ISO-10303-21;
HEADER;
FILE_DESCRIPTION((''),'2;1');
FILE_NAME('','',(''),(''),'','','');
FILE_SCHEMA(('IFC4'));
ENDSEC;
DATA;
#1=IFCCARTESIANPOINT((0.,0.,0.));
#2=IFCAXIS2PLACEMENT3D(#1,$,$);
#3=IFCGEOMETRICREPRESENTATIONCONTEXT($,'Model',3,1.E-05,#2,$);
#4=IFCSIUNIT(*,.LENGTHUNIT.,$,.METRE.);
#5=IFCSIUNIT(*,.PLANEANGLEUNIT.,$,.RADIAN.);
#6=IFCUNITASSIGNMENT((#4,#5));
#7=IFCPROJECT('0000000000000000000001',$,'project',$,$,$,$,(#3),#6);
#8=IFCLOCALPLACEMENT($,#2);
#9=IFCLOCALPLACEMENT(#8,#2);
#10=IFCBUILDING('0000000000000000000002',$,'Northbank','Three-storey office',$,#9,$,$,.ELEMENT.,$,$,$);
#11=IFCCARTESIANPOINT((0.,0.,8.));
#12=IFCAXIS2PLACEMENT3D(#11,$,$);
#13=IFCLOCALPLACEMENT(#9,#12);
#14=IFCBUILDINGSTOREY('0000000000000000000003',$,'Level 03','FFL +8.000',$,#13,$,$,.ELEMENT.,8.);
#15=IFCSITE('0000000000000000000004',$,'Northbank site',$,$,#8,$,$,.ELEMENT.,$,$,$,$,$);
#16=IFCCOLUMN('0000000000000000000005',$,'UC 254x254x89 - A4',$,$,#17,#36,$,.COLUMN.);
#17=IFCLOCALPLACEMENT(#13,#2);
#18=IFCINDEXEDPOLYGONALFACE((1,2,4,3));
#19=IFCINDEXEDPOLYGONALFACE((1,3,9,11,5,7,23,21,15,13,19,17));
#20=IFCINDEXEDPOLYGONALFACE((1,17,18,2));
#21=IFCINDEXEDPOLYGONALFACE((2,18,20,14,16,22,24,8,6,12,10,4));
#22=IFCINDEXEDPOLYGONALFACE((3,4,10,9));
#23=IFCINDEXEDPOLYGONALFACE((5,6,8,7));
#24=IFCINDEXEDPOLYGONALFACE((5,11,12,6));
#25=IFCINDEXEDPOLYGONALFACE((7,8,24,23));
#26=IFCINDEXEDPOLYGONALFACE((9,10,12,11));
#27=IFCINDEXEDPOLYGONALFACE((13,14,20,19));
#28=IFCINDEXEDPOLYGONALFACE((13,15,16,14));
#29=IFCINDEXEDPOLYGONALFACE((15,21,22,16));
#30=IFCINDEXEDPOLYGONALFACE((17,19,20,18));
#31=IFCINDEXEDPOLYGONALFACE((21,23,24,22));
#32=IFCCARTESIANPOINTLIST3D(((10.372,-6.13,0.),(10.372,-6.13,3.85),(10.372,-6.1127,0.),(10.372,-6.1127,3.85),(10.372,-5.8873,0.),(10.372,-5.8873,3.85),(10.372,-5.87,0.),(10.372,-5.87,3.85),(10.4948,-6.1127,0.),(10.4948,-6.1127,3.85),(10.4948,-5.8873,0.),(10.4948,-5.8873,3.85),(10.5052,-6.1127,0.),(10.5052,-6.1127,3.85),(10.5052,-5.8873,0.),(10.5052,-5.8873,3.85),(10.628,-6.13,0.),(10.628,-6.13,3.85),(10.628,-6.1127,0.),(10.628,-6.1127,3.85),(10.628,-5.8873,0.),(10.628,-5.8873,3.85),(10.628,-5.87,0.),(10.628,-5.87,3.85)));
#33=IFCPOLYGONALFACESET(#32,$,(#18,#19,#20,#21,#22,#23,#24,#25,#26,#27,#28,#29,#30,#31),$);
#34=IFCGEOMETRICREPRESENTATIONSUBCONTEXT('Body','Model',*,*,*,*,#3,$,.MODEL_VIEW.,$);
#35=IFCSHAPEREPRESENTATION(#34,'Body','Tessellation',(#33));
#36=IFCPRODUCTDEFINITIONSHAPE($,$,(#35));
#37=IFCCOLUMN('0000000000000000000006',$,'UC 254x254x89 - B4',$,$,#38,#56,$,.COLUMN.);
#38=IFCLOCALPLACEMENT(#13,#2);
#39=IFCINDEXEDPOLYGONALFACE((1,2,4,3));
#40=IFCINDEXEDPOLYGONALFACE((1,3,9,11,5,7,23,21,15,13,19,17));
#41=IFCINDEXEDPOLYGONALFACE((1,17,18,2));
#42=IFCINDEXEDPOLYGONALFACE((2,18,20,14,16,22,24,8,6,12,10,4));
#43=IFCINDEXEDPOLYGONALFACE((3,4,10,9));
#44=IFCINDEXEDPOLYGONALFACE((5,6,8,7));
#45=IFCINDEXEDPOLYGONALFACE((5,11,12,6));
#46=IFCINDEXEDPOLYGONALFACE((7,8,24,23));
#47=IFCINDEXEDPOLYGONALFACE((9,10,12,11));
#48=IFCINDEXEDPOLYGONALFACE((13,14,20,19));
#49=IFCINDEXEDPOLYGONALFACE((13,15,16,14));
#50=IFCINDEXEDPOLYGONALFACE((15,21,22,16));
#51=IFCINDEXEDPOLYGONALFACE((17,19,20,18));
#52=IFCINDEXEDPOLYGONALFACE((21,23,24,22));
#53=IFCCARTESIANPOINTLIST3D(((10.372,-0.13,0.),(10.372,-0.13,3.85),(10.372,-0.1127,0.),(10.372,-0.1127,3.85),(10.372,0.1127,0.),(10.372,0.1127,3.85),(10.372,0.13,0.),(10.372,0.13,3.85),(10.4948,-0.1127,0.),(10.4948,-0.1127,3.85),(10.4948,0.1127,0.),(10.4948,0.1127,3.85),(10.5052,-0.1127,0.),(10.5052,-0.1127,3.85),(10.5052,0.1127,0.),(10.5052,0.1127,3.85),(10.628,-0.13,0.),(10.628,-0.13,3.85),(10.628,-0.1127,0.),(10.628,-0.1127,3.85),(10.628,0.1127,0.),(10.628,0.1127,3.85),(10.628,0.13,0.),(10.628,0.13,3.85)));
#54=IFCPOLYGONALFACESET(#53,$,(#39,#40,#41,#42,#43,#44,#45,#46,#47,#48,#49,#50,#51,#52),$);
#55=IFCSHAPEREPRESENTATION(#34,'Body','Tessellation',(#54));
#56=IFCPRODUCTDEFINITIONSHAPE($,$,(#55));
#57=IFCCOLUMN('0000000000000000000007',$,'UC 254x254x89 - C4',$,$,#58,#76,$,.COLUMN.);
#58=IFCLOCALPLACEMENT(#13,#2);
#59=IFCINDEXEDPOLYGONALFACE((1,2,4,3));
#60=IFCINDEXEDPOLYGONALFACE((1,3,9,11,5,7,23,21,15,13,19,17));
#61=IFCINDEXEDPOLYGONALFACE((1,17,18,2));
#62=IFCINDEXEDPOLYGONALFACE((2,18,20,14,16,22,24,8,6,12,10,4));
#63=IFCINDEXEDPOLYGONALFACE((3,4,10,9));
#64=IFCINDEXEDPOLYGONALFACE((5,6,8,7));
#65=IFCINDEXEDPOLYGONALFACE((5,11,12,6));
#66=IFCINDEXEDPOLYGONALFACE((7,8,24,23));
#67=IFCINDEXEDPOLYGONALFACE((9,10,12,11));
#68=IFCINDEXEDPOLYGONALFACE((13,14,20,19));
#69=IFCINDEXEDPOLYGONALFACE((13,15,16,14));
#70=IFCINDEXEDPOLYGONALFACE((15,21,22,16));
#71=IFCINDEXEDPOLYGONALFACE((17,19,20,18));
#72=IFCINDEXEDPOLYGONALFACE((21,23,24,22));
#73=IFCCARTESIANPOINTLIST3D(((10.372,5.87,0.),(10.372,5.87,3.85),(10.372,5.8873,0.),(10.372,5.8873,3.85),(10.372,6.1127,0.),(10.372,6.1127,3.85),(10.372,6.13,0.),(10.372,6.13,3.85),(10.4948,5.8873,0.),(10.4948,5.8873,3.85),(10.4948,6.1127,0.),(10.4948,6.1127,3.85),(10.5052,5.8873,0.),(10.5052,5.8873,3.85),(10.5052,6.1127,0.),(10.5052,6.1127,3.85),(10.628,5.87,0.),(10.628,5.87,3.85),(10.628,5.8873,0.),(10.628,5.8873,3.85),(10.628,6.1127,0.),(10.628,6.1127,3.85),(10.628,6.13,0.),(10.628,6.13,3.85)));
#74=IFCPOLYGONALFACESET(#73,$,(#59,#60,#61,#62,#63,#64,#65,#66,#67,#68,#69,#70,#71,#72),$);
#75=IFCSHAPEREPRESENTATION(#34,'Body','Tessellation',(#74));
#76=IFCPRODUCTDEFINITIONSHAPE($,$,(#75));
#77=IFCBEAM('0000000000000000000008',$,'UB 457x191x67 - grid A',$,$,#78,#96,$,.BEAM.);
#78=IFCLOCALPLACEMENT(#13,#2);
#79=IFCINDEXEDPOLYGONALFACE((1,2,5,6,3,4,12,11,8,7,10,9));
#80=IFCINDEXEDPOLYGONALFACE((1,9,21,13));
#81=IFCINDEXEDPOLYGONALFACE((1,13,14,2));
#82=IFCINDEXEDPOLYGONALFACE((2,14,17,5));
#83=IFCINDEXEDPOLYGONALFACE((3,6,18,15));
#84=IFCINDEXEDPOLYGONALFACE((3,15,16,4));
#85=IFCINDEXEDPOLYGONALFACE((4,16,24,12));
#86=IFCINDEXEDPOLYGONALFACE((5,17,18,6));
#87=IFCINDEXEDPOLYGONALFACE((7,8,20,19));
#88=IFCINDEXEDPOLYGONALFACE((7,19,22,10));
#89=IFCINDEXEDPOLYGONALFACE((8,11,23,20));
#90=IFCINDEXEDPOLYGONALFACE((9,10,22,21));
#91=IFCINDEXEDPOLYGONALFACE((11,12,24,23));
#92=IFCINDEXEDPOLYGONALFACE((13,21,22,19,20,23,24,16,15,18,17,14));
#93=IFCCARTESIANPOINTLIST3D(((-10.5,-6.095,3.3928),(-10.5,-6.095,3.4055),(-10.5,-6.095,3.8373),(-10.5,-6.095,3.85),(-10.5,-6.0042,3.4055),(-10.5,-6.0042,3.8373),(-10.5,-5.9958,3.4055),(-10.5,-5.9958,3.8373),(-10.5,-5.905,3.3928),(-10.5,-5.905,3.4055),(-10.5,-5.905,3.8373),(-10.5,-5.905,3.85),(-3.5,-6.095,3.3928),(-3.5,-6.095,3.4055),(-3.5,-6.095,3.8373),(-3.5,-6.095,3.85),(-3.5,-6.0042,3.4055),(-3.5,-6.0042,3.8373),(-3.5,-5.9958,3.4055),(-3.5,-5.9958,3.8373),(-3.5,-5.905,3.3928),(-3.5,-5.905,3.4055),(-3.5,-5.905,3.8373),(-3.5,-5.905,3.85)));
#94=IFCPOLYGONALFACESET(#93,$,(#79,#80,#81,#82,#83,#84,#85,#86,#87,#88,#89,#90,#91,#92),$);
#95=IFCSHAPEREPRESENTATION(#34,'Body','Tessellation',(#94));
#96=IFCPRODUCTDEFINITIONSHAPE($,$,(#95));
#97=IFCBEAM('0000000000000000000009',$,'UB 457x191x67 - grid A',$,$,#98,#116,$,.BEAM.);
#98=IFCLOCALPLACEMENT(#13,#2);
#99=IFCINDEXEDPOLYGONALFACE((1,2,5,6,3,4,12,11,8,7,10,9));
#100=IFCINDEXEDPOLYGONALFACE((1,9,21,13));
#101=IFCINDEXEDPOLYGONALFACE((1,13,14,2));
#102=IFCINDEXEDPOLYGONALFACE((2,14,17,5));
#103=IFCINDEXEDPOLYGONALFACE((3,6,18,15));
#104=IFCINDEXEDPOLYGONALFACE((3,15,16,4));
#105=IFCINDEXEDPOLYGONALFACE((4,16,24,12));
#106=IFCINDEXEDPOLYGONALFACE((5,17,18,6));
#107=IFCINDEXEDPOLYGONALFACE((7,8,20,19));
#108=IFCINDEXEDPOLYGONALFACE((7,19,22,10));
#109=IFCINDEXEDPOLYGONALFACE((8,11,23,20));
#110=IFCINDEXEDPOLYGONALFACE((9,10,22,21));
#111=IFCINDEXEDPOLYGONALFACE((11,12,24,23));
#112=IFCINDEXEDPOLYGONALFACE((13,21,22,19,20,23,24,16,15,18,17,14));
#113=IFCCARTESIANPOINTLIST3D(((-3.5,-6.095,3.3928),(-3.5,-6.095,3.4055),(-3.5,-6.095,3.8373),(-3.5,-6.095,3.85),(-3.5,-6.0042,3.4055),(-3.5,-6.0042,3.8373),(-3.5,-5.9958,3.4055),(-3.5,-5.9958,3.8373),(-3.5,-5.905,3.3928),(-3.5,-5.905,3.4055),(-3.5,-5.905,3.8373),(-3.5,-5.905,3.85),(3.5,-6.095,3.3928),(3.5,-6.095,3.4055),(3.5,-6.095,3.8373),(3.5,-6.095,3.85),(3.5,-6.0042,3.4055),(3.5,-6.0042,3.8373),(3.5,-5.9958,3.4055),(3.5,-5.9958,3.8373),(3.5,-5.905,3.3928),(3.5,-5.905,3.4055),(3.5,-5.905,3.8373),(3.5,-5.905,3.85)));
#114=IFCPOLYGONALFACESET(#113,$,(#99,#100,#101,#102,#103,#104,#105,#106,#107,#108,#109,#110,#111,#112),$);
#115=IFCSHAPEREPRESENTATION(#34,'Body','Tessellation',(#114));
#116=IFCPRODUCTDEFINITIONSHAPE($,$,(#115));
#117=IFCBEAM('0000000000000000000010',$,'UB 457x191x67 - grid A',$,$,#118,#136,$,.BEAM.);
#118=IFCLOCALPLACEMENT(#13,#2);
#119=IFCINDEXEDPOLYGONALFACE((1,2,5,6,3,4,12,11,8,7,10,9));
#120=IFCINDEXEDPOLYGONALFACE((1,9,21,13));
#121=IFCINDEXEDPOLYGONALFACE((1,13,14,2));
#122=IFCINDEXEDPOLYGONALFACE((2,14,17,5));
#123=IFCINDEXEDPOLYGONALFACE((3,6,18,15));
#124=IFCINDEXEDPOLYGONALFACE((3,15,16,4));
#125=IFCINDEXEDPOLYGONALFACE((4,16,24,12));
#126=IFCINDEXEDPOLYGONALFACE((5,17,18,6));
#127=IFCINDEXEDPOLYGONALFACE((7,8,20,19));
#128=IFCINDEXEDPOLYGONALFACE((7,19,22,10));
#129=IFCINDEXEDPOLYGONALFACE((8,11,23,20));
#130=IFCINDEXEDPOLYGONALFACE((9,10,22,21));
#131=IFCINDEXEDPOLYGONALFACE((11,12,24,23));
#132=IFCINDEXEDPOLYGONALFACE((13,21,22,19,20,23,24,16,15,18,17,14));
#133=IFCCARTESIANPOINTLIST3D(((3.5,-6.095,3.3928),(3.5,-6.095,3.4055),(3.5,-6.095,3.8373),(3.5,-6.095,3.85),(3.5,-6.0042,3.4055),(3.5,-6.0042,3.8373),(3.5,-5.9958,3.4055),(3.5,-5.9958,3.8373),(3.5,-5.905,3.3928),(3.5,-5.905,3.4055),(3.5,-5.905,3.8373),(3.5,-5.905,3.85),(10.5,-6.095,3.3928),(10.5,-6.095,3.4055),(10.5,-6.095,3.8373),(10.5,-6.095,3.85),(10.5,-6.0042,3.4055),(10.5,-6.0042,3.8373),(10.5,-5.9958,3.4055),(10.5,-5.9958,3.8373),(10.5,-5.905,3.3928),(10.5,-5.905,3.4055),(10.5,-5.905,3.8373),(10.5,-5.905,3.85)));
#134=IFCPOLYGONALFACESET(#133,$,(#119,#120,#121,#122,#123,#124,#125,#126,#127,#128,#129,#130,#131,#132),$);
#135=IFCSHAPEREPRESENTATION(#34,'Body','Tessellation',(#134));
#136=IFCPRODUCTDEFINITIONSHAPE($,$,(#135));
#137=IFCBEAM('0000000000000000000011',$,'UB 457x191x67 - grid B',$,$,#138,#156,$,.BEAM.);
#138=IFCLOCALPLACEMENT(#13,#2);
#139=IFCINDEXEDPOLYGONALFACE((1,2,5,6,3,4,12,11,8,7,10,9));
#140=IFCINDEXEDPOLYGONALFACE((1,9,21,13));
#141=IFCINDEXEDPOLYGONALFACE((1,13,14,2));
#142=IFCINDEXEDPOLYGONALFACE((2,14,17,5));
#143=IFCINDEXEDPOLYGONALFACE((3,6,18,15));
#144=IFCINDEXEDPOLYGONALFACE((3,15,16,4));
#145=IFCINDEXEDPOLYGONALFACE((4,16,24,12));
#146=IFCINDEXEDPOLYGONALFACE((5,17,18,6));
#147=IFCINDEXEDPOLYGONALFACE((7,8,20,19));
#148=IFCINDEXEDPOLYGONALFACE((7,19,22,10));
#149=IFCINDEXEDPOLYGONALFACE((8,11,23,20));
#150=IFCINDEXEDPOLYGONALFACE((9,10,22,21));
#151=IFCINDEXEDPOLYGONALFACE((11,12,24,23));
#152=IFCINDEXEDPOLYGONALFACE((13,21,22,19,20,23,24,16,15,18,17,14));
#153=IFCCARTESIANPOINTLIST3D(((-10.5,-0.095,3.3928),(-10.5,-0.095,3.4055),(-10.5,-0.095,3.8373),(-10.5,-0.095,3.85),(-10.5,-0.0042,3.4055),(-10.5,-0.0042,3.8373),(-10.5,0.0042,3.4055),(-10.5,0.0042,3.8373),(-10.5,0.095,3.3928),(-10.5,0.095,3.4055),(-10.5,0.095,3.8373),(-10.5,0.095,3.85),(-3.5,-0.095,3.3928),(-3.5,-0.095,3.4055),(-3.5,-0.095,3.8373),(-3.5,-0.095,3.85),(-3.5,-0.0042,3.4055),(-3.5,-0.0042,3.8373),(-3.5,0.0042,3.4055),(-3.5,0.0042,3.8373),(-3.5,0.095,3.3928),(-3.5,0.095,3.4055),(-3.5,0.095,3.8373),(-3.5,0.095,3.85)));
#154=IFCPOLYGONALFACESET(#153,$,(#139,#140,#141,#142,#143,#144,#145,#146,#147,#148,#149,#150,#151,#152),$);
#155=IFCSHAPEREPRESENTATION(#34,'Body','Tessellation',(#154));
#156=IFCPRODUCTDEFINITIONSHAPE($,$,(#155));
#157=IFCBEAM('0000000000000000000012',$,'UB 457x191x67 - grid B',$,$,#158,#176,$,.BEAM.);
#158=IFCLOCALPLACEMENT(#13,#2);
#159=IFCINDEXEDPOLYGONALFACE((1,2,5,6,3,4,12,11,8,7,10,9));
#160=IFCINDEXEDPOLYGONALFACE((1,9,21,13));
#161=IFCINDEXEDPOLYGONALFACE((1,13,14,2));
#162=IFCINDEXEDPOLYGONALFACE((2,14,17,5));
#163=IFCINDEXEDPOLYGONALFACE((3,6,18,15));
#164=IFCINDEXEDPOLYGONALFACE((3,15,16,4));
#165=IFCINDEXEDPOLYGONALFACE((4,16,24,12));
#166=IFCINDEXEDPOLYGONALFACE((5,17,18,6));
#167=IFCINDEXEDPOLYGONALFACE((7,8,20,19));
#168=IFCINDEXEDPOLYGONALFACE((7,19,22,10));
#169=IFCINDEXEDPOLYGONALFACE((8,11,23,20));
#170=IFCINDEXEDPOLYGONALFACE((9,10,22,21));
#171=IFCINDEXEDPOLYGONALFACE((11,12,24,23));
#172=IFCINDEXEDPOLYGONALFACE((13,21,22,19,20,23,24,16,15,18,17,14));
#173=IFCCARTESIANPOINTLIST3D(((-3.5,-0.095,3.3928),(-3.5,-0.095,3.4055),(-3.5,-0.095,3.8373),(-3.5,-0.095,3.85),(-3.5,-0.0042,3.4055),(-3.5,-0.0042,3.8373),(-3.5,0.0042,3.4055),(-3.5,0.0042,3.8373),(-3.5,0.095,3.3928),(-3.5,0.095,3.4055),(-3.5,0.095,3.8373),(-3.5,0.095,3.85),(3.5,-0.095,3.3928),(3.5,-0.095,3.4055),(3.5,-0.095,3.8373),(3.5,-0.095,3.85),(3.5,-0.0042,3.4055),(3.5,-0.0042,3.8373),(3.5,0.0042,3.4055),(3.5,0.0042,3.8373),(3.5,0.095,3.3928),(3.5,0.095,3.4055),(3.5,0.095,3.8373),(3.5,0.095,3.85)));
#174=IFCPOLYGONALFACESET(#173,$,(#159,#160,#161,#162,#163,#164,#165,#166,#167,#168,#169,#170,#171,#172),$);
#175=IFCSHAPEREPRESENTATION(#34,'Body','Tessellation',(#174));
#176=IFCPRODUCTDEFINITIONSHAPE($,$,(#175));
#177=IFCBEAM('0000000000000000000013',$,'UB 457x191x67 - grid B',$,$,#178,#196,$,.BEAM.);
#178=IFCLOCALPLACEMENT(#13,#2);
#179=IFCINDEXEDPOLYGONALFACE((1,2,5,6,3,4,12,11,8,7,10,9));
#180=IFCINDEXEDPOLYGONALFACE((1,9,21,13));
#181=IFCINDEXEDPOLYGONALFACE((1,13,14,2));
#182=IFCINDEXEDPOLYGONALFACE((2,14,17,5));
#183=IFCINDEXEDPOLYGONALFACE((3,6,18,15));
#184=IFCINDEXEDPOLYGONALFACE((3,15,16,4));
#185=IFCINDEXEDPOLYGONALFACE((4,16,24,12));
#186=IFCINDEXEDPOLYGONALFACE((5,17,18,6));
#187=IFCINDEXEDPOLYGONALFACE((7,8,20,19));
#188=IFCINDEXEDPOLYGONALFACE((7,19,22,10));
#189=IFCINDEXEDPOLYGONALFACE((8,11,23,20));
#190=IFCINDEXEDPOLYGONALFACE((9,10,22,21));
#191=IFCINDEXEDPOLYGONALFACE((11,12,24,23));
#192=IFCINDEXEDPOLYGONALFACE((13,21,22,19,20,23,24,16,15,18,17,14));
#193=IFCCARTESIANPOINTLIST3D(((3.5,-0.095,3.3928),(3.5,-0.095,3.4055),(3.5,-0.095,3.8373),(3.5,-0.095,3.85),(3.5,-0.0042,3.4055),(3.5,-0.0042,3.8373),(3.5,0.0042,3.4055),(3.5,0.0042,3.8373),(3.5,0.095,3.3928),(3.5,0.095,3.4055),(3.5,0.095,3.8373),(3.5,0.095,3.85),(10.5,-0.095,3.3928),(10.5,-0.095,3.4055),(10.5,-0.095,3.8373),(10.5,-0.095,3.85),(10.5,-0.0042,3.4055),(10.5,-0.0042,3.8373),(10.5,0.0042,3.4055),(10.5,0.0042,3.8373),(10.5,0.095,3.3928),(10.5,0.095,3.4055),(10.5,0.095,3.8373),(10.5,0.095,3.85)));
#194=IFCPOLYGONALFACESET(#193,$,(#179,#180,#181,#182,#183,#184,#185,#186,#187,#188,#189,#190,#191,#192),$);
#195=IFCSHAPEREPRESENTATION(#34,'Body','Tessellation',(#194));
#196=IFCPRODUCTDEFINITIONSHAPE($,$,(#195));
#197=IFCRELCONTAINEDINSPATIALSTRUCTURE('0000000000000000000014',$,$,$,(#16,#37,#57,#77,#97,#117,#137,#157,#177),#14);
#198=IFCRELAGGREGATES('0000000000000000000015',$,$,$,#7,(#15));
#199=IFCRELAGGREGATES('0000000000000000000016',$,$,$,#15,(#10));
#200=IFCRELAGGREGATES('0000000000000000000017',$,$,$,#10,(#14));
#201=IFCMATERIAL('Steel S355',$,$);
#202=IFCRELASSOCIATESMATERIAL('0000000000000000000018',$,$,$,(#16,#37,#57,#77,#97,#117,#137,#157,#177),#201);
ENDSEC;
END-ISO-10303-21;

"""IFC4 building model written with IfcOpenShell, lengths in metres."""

from ifc_helpers import new_model, si_unit, frame, origin, place, context, subcontext, project, spatial, i_section, extrude, material, element, save


model = new_model("IFC4")

# Units and contexts
model_context = context("Model", 3, precision=1e-05, world=origin())
body_context = subcontext(model_context, "Body", "Model", "MODEL_VIEW")
ifc_project = project(units=[si_unit("LENGTHUNIT", "METRE"), si_unit("PLANEANGLEUNIT", "RADIAN")], contexts=[model_context])

# Site, building, storey
site_placement = place(None, origin())
site = spatial("IfcSite", under=ifc_project, at=site_placement, Name="Northbank site", CompositionType="ELEMENT")
building_placement = place(site_placement, origin())
building = spatial("IfcBuilding", under=site, at=building_placement, Name="Northbank", Description="Three-storey office", CompositionType="ELEMENT")
storey_placement = place(building_placement, frame((0.0, 0.0, 8.0)))
storey = spatial("IfcBuildingStorey", under=building, at=storey_placement, Name="Level 03", Description="FFL +8.000", CompositionType="ELEMENT", Elevation=8.0)

# Columns
ifc_material = material(Name="Steel S355")
column_1_placement = place(storey_placement, frame((0.0, 0.0, -8.0)))
element("IfcColumn", 1, at=column_1_placement, inside=storey, material=ifc_material, Name="UC 254x254x89 - A4", PredefinedType="COLUMN", context=body_context, shape_type="SweptSolid", body=[
    extrude(i_section(OverallWidth=0.256, OverallDepth=0.26, WebThickness=0.0103, FlangeThickness=0.0173), frame((10.5, -6.0, 8.0), z_axis=(0.0, 0.0, 1.0), x_axis=(1.0, 0.0, 0.0)), (0.0, 0.0, 1.0), 3.85),
])
column_2_placement = place(storey_placement, frame((0.0, 0.0, -8.0)))
element("IfcColumn", 2, at=column_2_placement, inside=storey, material=ifc_material, Name="UC 254x254x89 - B4", PredefinedType="COLUMN", context=body_context, shape_type="SweptSolid", body=[
    extrude(i_section(OverallWidth=0.256, OverallDepth=0.26, WebThickness=0.0103, FlangeThickness=0.0173), frame((10.5, 0.0, 8.0), z_axis=(0.0, 0.0, 1.0), x_axis=(1.0, 0.0, 0.0)), (0.0, 0.0, 1.0), 3.85),
])
column_3_placement = place(storey_placement, frame((0.0, 0.0, -8.0)))
element("IfcColumn", 3, at=column_3_placement, inside=storey, material=ifc_material, Name="UC 254x254x89 - C4", PredefinedType="COLUMN", context=body_context, shape_type="SweptSolid", body=[
    extrude(i_section(OverallWidth=0.256, OverallDepth=0.26, WebThickness=0.0103, FlangeThickness=0.0173), frame((10.5, 6.0, 8.0), z_axis=(0.0, 0.0, 1.0), x_axis=(1.0, 0.0, 0.0)), (0.0, 0.0, 1.0), 3.85),
])

# Beams
beam_1_placement = place(storey_placement, frame((0.0, 0.0, -8.0)))
element("IfcBeam", 4, at=beam_1_placement, inside=storey, material=ifc_material, Name="UB 457x191x67 - grid A", PredefinedType="BEAM", context=body_context, shape_type="SweptSolid", body=[
    extrude(i_section(OverallWidth=0.1899, OverallDepth=0.4572, WebThickness=0.0085, FlangeThickness=0.0127), frame((-10.5, -6.0, 11.6214), z_axis=(1.0, 0.0, 0.0), x_axis=(0.0, 1.0, 0.0)), (0.0, 0.0, 1.0), 7.0),
])
beam_2_placement = place(storey_placement, frame((0.0, 0.0, -8.0)))
element("IfcBeam", 5, at=beam_2_placement, inside=storey, material=ifc_material, Name="UB 457x191x67 - grid A", PredefinedType="BEAM", context=body_context, shape_type="SweptSolid", body=[
    extrude(i_section(OverallWidth=0.1899, OverallDepth=0.4572, WebThickness=0.0085, FlangeThickness=0.0127), frame((-3.5, -6.0, 11.6214), z_axis=(1.0, 0.0, 0.0), x_axis=(0.0, 1.0, 0.0)), (0.0, 0.0, 1.0), 7.0),
])
beam_3_placement = place(storey_placement, frame((0.0, 0.0, -8.0)))
element("IfcBeam", 6, at=beam_3_placement, inside=storey, material=ifc_material, Name="UB 457x191x67 - grid A", PredefinedType="BEAM", context=body_context, shape_type="SweptSolid", body=[
    extrude(i_section(OverallWidth=0.1899, OverallDepth=0.4572, WebThickness=0.0085, FlangeThickness=0.0127), frame((3.5, -6.0, 11.6214), z_axis=(1.0, 0.0, 0.0), x_axis=(0.0, 1.0, 0.0)), (0.0, 0.0, 1.0), 7.0),
])
beam_4_placement = place(storey_placement, frame((0.0, 0.0, -8.0)))
element("IfcBeam", 7, at=beam_4_placement, inside=storey, material=ifc_material, Name="UB 457x191x67 - grid B", PredefinedType="BEAM", context=body_context, shape_type="SweptSolid", body=[
    extrude(i_section(OverallWidth=0.1899, OverallDepth=0.4572, WebThickness=0.0085, FlangeThickness=0.0127), frame((-10.5, 0.0, 11.6214), z_axis=(1.0, 0.0, 0.0), x_axis=(0.0, 1.0, 0.0)), (0.0, 0.0, 1.0), 7.0),
])
beam_5_placement = place(storey_placement, frame((0.0, 0.0, -8.0)))
element("IfcBeam", 8, at=beam_5_placement, inside=storey, material=ifc_material, Name="UB 457x191x67 - grid B", PredefinedType="BEAM", context=body_context, shape_type="SweptSolid", body=[
    extrude(i_section(OverallWidth=0.1899, OverallDepth=0.4572, WebThickness=0.0085, FlangeThickness=0.0127), frame((-3.5, 0.0, 11.6214), z_axis=(1.0, 0.0, 0.0), x_axis=(0.0, 1.0, 0.0)), (0.0, 0.0, 1.0), 7.0),
])
beam_6_placement = place(storey_placement, frame((0.0, 0.0, -8.0)))
element("IfcBeam", 9, at=beam_6_placement, inside=storey, material=ifc_material, Name="UB 457x191x67 - grid B", PredefinedType="BEAM", context=body_context, shape_type="SweptSolid", body=[
    extrude(i_section(OverallWidth=0.1899, OverallDepth=0.4572, WebThickness=0.0085, FlangeThickness=0.0127), frame((3.5, 0.0, 11.6214), z_axis=(1.0, 0.0, 0.0), x_axis=(0.0, 1.0, 0.0)), (0.0, 0.0, 1.0), 7.0),
])

save(model, "model.ifc")
